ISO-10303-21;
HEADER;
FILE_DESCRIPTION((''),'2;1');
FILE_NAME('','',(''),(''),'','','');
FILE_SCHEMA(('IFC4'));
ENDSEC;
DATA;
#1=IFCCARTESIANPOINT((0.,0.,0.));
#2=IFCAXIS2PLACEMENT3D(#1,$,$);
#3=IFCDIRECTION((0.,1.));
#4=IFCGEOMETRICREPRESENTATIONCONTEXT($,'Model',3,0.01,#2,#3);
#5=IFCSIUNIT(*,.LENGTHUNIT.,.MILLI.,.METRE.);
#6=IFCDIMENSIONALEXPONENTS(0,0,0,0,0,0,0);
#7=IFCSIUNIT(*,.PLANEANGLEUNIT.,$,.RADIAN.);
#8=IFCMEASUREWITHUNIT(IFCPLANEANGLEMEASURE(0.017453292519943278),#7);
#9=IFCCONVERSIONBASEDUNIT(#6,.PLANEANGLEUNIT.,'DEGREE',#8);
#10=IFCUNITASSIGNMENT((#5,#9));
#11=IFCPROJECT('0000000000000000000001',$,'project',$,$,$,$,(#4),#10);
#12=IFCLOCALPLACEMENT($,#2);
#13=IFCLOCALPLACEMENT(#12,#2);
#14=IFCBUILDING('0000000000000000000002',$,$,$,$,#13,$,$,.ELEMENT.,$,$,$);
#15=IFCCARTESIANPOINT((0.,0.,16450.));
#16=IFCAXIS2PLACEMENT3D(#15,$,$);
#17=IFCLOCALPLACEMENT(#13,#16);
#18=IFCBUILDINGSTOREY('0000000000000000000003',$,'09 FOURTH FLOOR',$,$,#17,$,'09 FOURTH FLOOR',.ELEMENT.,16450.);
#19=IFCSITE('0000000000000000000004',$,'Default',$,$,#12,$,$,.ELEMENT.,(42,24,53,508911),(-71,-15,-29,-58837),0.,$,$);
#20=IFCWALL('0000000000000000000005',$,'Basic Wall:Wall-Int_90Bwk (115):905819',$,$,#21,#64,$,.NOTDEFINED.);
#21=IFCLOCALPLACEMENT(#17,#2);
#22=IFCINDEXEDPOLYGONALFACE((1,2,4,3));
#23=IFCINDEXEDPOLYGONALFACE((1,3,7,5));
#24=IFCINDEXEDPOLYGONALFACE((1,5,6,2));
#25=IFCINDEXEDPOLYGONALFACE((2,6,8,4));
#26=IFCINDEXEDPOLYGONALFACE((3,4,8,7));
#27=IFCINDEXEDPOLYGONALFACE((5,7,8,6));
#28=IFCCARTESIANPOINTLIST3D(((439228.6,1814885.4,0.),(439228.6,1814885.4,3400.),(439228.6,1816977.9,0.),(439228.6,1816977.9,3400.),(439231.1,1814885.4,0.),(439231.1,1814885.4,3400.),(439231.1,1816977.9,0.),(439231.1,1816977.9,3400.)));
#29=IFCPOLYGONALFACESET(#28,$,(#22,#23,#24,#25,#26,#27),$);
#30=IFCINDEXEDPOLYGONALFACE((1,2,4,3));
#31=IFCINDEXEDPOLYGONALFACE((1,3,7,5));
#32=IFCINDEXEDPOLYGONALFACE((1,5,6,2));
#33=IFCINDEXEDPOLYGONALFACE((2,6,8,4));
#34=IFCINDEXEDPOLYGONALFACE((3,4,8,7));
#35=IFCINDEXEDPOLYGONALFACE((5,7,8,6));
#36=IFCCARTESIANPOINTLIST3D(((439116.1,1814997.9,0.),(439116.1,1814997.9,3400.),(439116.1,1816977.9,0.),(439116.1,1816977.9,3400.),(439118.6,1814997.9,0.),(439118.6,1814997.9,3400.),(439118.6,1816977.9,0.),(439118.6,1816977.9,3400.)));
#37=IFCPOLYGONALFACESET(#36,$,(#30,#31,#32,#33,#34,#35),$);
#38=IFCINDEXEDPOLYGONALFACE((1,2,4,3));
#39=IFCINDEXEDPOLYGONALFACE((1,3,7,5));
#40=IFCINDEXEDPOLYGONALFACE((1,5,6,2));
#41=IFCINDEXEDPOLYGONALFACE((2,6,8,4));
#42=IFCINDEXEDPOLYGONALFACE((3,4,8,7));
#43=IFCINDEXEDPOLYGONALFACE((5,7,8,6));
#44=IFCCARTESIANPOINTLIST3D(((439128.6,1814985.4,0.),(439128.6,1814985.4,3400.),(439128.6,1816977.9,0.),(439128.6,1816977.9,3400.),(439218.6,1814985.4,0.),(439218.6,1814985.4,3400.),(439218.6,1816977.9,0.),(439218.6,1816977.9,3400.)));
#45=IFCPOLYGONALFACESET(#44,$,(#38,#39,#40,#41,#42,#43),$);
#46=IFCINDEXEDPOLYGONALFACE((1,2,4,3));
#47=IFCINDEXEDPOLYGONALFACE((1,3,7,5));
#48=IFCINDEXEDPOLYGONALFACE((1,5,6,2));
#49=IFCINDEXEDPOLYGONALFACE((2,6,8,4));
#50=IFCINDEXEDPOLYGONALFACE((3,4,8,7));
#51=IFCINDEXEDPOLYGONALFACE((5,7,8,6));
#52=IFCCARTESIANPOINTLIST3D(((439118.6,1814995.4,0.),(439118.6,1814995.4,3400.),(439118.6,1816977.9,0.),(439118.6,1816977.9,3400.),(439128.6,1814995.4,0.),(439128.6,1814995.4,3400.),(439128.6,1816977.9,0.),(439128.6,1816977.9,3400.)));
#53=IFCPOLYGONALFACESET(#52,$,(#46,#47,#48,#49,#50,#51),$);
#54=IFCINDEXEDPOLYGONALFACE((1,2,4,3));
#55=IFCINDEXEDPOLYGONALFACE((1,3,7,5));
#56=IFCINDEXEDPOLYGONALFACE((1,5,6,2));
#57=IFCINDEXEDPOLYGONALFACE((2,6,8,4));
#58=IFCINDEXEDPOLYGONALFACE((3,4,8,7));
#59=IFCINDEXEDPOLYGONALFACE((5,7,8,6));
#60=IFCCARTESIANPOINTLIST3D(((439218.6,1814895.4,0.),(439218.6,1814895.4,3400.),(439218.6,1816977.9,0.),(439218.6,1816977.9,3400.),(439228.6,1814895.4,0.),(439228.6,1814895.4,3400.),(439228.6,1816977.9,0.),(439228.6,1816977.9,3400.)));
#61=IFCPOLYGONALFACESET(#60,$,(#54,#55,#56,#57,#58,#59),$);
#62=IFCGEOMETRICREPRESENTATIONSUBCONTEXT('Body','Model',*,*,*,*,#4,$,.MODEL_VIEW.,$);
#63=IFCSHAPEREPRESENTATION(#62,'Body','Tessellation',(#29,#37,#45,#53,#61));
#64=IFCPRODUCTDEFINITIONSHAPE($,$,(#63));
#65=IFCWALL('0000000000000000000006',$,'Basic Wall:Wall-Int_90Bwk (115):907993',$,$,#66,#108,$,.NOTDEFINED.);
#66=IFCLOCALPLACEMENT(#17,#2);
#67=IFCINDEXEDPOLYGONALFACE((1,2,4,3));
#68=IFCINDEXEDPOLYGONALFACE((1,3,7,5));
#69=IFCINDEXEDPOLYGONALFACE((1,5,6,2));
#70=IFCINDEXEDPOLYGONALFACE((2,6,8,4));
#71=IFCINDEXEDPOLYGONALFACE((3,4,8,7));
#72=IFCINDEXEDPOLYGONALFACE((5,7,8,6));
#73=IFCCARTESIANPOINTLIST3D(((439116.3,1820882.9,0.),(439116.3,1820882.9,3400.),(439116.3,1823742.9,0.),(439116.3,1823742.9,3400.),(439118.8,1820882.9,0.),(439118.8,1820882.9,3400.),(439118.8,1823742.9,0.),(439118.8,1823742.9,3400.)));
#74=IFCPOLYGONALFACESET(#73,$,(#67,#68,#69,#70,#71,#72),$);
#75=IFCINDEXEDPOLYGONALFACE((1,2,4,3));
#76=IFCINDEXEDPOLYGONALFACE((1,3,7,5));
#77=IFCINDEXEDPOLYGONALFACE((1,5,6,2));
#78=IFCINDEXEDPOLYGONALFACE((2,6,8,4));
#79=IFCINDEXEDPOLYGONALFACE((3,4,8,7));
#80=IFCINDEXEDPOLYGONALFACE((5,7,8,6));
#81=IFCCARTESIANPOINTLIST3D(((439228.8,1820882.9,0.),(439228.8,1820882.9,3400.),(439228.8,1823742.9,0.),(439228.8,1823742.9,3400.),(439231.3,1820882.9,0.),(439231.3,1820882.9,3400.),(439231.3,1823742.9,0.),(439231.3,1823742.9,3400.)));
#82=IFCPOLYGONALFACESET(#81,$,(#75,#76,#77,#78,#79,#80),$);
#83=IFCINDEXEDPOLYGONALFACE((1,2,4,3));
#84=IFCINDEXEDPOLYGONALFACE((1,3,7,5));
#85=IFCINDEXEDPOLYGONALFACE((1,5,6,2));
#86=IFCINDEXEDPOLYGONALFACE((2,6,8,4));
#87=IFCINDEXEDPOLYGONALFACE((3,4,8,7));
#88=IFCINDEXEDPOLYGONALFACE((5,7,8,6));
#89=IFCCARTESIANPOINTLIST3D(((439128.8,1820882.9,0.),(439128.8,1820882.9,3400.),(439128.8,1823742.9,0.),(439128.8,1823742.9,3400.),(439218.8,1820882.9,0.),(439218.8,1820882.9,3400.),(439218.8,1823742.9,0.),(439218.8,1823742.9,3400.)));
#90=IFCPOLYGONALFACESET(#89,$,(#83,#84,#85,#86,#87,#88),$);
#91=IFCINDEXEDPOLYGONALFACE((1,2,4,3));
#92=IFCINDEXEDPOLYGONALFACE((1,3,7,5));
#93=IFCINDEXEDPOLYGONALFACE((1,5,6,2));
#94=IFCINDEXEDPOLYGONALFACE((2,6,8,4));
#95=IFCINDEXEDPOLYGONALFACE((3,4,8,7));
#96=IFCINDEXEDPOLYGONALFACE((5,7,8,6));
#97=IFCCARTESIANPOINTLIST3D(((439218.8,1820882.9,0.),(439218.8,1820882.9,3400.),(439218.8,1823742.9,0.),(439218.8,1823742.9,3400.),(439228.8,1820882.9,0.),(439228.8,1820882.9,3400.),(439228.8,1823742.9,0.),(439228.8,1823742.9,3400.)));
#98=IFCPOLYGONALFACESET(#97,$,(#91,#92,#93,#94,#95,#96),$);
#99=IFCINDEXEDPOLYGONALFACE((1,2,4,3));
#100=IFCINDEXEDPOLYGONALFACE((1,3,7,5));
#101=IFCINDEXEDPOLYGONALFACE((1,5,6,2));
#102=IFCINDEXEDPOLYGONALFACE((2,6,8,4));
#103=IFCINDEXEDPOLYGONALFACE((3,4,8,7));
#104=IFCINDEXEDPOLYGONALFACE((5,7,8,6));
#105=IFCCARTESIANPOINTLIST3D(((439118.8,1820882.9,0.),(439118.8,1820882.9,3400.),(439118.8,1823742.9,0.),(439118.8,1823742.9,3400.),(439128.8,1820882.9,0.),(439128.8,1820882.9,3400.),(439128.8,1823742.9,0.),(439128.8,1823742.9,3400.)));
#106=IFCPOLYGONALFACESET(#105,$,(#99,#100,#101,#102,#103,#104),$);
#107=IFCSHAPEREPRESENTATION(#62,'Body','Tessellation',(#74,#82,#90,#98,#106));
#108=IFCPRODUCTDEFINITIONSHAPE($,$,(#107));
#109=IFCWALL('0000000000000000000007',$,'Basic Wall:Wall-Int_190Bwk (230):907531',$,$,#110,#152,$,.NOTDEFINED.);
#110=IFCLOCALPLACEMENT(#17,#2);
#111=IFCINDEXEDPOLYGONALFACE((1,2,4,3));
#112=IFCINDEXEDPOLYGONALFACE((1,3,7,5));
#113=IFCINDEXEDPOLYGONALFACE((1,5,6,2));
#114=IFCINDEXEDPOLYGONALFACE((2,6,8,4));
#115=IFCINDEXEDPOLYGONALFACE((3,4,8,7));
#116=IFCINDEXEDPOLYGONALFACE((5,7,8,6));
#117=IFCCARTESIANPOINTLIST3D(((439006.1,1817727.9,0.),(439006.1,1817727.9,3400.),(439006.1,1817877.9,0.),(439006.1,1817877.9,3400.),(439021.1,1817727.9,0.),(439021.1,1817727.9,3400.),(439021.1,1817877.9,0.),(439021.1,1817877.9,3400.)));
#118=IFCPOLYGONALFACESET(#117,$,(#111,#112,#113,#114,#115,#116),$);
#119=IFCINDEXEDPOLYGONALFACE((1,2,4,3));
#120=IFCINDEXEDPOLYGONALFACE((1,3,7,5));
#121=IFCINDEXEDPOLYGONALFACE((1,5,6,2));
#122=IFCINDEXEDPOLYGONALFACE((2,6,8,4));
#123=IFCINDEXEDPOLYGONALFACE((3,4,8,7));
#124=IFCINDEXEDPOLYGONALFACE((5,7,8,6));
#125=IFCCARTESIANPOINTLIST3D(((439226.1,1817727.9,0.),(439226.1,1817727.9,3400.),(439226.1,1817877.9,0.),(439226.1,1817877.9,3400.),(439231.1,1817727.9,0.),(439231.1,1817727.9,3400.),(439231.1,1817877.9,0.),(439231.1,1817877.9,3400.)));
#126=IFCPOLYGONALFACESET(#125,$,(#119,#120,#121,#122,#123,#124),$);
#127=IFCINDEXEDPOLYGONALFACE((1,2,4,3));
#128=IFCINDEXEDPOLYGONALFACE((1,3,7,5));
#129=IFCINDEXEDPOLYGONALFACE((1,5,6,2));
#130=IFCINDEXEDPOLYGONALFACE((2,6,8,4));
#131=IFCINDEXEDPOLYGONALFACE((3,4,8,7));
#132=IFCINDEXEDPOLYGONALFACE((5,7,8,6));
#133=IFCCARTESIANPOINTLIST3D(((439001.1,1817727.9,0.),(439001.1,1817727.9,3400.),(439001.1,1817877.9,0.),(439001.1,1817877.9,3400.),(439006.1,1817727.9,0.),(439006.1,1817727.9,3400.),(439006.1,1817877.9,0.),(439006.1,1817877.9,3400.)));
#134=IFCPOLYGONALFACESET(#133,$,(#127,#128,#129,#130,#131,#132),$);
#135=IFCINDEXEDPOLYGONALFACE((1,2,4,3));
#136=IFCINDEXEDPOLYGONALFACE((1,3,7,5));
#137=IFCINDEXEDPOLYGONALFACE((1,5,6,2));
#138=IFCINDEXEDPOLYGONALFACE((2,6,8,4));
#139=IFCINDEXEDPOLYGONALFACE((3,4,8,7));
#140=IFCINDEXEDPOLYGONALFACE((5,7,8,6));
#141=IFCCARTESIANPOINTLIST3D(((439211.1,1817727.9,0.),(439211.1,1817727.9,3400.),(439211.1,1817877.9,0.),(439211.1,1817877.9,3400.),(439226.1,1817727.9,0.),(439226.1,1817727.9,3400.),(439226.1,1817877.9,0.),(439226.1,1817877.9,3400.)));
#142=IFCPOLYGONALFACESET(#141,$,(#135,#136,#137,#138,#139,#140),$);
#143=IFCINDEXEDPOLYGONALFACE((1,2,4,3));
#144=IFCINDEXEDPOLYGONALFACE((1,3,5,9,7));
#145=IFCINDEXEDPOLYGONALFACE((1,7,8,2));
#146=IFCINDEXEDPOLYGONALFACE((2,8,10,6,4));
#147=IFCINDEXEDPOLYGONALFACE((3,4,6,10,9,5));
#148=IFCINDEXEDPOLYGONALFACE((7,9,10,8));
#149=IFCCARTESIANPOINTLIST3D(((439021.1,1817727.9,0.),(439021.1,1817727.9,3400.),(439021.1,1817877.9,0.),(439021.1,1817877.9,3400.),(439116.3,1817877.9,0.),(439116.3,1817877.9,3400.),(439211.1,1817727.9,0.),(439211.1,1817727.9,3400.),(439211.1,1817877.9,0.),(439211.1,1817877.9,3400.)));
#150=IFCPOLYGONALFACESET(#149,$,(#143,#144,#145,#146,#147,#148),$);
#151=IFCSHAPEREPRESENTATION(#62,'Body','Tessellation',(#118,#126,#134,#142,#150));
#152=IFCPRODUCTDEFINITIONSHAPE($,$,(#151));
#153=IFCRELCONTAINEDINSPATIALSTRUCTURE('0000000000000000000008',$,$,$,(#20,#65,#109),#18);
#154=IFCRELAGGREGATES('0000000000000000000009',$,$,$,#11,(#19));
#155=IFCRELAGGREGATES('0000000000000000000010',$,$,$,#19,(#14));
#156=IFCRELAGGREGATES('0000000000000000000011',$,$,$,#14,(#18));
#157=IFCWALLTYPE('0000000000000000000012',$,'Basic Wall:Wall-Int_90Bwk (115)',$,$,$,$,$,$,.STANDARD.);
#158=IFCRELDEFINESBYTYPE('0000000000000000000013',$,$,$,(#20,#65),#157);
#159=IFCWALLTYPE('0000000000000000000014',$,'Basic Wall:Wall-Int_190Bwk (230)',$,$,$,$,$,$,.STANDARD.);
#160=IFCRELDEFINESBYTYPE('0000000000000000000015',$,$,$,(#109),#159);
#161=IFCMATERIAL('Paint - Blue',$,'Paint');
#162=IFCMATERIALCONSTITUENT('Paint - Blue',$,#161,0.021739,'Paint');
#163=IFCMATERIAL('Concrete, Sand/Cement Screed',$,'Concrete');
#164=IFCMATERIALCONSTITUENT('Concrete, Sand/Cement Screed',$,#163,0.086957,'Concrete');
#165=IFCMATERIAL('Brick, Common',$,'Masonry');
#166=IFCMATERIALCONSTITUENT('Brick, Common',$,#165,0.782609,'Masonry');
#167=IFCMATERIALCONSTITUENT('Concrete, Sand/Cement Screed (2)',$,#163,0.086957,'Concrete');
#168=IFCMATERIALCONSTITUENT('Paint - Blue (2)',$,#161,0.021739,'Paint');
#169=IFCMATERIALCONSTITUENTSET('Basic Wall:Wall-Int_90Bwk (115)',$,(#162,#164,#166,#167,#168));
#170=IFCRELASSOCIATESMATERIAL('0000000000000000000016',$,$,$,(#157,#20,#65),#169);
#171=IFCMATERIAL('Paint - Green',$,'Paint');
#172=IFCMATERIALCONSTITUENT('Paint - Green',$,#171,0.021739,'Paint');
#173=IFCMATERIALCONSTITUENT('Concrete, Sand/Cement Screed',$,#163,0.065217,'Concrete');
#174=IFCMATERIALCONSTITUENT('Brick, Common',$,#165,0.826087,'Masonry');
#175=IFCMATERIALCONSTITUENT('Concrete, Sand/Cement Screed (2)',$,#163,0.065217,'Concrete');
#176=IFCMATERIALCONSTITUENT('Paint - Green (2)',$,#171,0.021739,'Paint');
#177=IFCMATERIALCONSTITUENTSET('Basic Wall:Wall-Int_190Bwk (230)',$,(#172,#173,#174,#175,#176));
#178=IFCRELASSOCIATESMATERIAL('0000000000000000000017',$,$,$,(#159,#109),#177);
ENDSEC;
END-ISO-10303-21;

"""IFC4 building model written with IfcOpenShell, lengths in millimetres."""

from ifc_helpers import new_model, entity, si_unit, converted_unit, direction, frame, origin, place, context, subcontext, project, spatial, indexed_curve, outline, extrude, material, constituent, constituent_set, type_object, element, save


model = new_model("IFC4")

# Units and contexts
model_context = context("Model", 3, precision=0.01, world=origin(), true_north=direction((0.0, 1.0)))
body_context = subcontext(model_context, "Body", "Model", "MODEL_VIEW")
ifc_project = project(units=[si_unit("LENGTHUNIT", "METRE", prefix="MILLI"), converted_unit("PLANEANGLEUNIT", "DEGREE", entity("IfcPlaneAngleMeasure", 0.017453292519943278), si_unit("PLANEANGLEUNIT", "RADIAN"), dimensions=[0, 0, 0, 0, 0, 0, 0])], contexts=[model_context])

# Site, building, storey
site_placement = place(None, origin())
site = spatial("IfcSite", under=ifc_project, at=site_placement, Name="Default", CompositionType="ELEMENT", RefLatitude=(42, 24, 53, 508911), RefLongitude=(-71, -15, -29, -58837), RefElevation=0.0)
building_placement = place(site_placement, origin())
building = spatial("IfcBuilding", under=site, at=building_placement, CompositionType="ELEMENT")
storey_placement = place(building_placement, frame((0.0, 0.0, 16450.0)))
storey = spatial("IfcBuildingStorey", under=building, at=storey_placement, Name="09 FOURTH FLOOR", LongName="09 FOURTH FLOOR", CompositionType="ELEMENT", Elevation=16450.0)

# Shared definitions
ifc_material_1 = material(Name="Paint - Blue", Category="Paint")
ifc_constituent_1 = constituent(ifc_material_1, Name="Paint - Blue", Category="Paint", fraction=0.021739)
ifc_material_2 = material(Name="Concrete, Sand/Cement Screed", Category="Concrete")
ifc_constituent_2 = constituent(ifc_material_2, Name="Concrete, Sand/Cement Screed", Category="Concrete", fraction=0.086957)
ifc_material_3 = material(Name="Brick, Common", Category="Masonry")
ifc_constituent_3 = constituent(ifc_material_3, Name="Brick, Common", Category="Masonry", fraction=0.782609)
ifc_constituent_4 = constituent(ifc_material_2, Name="Concrete, Sand/Cement Screed (2)", Category="Concrete", fraction=0.086957)
ifc_constituent_5 = constituent(ifc_material_1, Name="Paint - Blue (2)", Category="Paint", fraction=0.021739)
ifc_constituent_set_1 = constituent_set(constituents=[ifc_constituent_1, ifc_constituent_2, ifc_constituent_3, ifc_constituent_4, ifc_constituent_5], Name="Basic Wall:Wall-Int_90Bwk (115)")
wall_type_1 = type_object("IfcWallType", Name="Basic Wall:Wall-Int_90Bwk (115)", PredefinedType="STANDARD", material=ifc_constituent_set_1)

# Wall
wall_1_placement = place(storey_placement, frame((439173.6, 1814997.9, 0.0), z_axis=(0.0, 0.0, 1.0), x_axis=(0.0, 1.0, 0.0)))
element("IfcWall", 1, at=wall_1_placement, inside=storey, type_object=wall_type_1, material=ifc_constituent_set_1, Name="Basic Wall:Wall-Int_90Bwk (115):905819", PredefinedType="NOTDEFINED", context=body_context, shape_type="SweptSolid", body=[
    extrude(outline(indexed_curve([(-1.2, -1046.2), (1.3, -1046.2), (1.3, 1046.2), (-1.2, 1046.2), (-1.2, -1046.2)], self_intersect=False)), frame((933.7, -56.3, 0.0), z_axis=(0.0, 0.0, 1.0), x_axis=(0.0, 1.0, 0.0)), (0.0, 0.0, 1.0), 3400.0),
    extrude(outline(indexed_curve([(-1.3, -990.0), (1.2, -990.0), (1.2, 990.0), (-1.3, 990.0), (-1.3, -990.0)], self_intersect=False)), frame((990.0, 56.2, 0.0), z_axis=(0.0, 0.0, 1.0), x_axis=(0.0, -1.0, 0.0)), (0.0, 0.0, 1.0), 3400.0),
    extrude(outline(indexed_curve([(-996.2, -45.0), (996.2, -45.0), (996.2, 45.0), (-996.2, 45.0), (-996.2, -45.0)], self_intersect=False)), frame((983.7, 0.0, 0.0)), (0.0, 0.0, 1.0), 3400.0),
    extrude(outline(indexed_curve([(-991.2, -5.0), (991.2, -5.0), (991.2, 5.0), (-991.2, 5.0), (-991.2, -5.0)], self_intersect=False)), frame((988.7, 50.0, 0.0)), (0.0, 0.0, 1.0), 3400.0),
    extrude(outline(indexed_curve([(-1041.2, -5.0), (1041.2, -5.0), (1041.2, 5.0), (-1041.2, 5.0), (-1041.2, -5.0)], self_intersect=False)), frame((938.7, -50.0, 0.0)), (0.0, 0.0, 1.0), 3400.0),
])

# Wall
wall_2_placement = place(storey_placement, frame((439173.8, 1820882.9, 0.0), z_axis=(0.0, 0.0, 1.0), x_axis=(0.0, 1.0, 0.0)))
element("IfcWall", 2, at=wall_2_placement, inside=storey, type_object=wall_type_1, material=ifc_constituent_set_1, Name="Basic Wall:Wall-Int_90Bwk (115):907993", PredefinedType="NOTDEFINED", context=body_context, shape_type="SweptSolid", body=[
    extrude(outline(indexed_curve([(-1.2, -1430.0), (1.3, -1430.0), (1.3, 1430.0), (-1.2, 1430.0), (-1.2, -1430.0)], self_intersect=False)), frame((1430.0, 56.3, 0.0), z_axis=(0.0, 0.0, 1.0), x_axis=(0.0, -1.0, 0.0)), (0.0, 0.0, 1.0), 3400.0),
    extrude(outline(indexed_curve([(-1.2, -1430.0), (1.3, -1430.0), (1.3, 1430.0), (-1.2, 1430.0), (-1.2, -1430.0)], self_intersect=False)), frame((1430.0, -56.3, 0.0), z_axis=(0.0, 0.0, 1.0), x_axis=(0.0, 1.0, 0.0)), (0.0, 0.0, 1.0), 3400.0),
    extrude(outline(indexed_curve([(-1430.0, -45.0), (1430.0, -45.0), (1430.0, 45.0), (-1430.0, 45.0), (-1430.0, -45.0)], self_intersect=False)), frame((1430.0, 0.0, 0.0)), (0.0, 0.0, 1.0), 3400.0),
    extrude(outline(indexed_curve([(-1430.0, -5.0), (1430.0, -5.0), (1430.0, 5.0), (-1430.0, 5.0), (-1430.0, -5.0)], self_intersect=False)), frame((1430.0, -50.0, 0.0)), (0.0, 0.0, 1.0), 3400.0),
    extrude(outline(indexed_curve([(-1430.0, -5.0), (1430.0, -5.0), (1430.0, 5.0), (-1430.0, 5.0), (-1430.0, -5.0)], self_intersect=False)), frame((1430.0, 50.0, 0.0)), (0.0, 0.0, 1.0), 3400.0),
])

# Shared definitions
ifc_material_4 = material(Name="Paint - Green", Category="Paint")

# Shared definitions
ifc_constituent_6 = constituent(ifc_material_4, Name="Paint - Green", Category="Paint", fraction=0.021739)
ifc_constituent_7 = constituent(ifc_material_2, Name="Concrete, Sand/Cement Screed", Category="Concrete", fraction=0.065217)
ifc_constituent_8 = constituent(ifc_material_3, Name="Brick, Common", Category="Masonry", fraction=0.826087)
ifc_constituent_9 = constituent(ifc_material_2, Name="Concrete, Sand/Cement Screed (2)", Category="Concrete", fraction=0.065217)
ifc_constituent_10 = constituent(ifc_material_4, Name="Paint - Green (2)", Category="Paint", fraction=0.021739)
ifc_constituent_set_2 = constituent_set(constituents=[ifc_constituent_6, ifc_constituent_7, ifc_constituent_8, ifc_constituent_9, ifc_constituent_10], Name="Basic Wall:Wall-Int_190Bwk (230)")
wall_type_2 = type_object("IfcWallType", Name="Basic Wall:Wall-Int_190Bwk (230)", PredefinedType="STANDARD", material=ifc_constituent_set_2)

# Wall
wall_3_placement = place(storey_placement, frame((439116.1, 1817727.9, 0.0), z_axis=(0.0, 0.0, 1.0), x_axis=(0.0, 1.0, 0.0)))
element("IfcWall", 3, at=wall_3_placement, inside=storey, type_object=wall_type_2, material=ifc_constituent_set_2, Name="Basic Wall:Wall-Int_190Bwk (230):907531", PredefinedType="NOTDEFINED", context=body_context, shape_type="SweptSolid", body=[
    extrude(outline(indexed_curve([(-75.0, -7.5), (75.0, -7.5), (75.0, 7.5), (-75.0, 7.5), (-75.0, -7.5)], self_intersect=False)), frame((75.0, 102.5, 0.0)), (0.0, 0.0, 1.0), 3400.0),
    extrude(outline(indexed_curve([(-2.5, -75.0), (2.5, -75.0), (2.5, 75.0), (-2.5, 75.0), (-2.5, -75.0)], self_intersect=False)), frame((75.0, -112.5, 0.0), z_axis=(0.0, 0.0, 1.0), x_axis=(0.0, 1.0, 0.0)), (0.0, 0.0, 1.0), 3400.0),
    extrude(outline(indexed_curve([(-2.5, -75.0), (2.5, -75.0), (2.5, 75.0), (-2.5, 75.0), (-2.5, -75.0)], self_intersect=False)), frame((75.0, 112.5, 0.0), z_axis=(0.0, 0.0, 1.0), x_axis=(0.0, -1.0, 0.0)), (0.0, 0.0, 1.0), 3400.0),
    extrude(outline(indexed_curve([(-75.0, -7.5), (75.0, -7.5), (75.0, 7.5), (-75.0, 7.5), (-75.0, -7.5)], self_intersect=False)), frame((75.0, -102.5, 0.0)), (0.0, 0.0, 1.0), 3400.0),
    extrude(outline(indexed_curve([(-90.0, -95.0), (60.0, -95.0), (60.0, -0.1), (60.0, 95.0), (-90.0, 95.0), (-90.0, -95.0)], self_intersect=False)), frame((90.0, 0.0, 0.0)), (0.0, 0.0, 1.0), 3400.0),
])

save(model, "model.ifc")
